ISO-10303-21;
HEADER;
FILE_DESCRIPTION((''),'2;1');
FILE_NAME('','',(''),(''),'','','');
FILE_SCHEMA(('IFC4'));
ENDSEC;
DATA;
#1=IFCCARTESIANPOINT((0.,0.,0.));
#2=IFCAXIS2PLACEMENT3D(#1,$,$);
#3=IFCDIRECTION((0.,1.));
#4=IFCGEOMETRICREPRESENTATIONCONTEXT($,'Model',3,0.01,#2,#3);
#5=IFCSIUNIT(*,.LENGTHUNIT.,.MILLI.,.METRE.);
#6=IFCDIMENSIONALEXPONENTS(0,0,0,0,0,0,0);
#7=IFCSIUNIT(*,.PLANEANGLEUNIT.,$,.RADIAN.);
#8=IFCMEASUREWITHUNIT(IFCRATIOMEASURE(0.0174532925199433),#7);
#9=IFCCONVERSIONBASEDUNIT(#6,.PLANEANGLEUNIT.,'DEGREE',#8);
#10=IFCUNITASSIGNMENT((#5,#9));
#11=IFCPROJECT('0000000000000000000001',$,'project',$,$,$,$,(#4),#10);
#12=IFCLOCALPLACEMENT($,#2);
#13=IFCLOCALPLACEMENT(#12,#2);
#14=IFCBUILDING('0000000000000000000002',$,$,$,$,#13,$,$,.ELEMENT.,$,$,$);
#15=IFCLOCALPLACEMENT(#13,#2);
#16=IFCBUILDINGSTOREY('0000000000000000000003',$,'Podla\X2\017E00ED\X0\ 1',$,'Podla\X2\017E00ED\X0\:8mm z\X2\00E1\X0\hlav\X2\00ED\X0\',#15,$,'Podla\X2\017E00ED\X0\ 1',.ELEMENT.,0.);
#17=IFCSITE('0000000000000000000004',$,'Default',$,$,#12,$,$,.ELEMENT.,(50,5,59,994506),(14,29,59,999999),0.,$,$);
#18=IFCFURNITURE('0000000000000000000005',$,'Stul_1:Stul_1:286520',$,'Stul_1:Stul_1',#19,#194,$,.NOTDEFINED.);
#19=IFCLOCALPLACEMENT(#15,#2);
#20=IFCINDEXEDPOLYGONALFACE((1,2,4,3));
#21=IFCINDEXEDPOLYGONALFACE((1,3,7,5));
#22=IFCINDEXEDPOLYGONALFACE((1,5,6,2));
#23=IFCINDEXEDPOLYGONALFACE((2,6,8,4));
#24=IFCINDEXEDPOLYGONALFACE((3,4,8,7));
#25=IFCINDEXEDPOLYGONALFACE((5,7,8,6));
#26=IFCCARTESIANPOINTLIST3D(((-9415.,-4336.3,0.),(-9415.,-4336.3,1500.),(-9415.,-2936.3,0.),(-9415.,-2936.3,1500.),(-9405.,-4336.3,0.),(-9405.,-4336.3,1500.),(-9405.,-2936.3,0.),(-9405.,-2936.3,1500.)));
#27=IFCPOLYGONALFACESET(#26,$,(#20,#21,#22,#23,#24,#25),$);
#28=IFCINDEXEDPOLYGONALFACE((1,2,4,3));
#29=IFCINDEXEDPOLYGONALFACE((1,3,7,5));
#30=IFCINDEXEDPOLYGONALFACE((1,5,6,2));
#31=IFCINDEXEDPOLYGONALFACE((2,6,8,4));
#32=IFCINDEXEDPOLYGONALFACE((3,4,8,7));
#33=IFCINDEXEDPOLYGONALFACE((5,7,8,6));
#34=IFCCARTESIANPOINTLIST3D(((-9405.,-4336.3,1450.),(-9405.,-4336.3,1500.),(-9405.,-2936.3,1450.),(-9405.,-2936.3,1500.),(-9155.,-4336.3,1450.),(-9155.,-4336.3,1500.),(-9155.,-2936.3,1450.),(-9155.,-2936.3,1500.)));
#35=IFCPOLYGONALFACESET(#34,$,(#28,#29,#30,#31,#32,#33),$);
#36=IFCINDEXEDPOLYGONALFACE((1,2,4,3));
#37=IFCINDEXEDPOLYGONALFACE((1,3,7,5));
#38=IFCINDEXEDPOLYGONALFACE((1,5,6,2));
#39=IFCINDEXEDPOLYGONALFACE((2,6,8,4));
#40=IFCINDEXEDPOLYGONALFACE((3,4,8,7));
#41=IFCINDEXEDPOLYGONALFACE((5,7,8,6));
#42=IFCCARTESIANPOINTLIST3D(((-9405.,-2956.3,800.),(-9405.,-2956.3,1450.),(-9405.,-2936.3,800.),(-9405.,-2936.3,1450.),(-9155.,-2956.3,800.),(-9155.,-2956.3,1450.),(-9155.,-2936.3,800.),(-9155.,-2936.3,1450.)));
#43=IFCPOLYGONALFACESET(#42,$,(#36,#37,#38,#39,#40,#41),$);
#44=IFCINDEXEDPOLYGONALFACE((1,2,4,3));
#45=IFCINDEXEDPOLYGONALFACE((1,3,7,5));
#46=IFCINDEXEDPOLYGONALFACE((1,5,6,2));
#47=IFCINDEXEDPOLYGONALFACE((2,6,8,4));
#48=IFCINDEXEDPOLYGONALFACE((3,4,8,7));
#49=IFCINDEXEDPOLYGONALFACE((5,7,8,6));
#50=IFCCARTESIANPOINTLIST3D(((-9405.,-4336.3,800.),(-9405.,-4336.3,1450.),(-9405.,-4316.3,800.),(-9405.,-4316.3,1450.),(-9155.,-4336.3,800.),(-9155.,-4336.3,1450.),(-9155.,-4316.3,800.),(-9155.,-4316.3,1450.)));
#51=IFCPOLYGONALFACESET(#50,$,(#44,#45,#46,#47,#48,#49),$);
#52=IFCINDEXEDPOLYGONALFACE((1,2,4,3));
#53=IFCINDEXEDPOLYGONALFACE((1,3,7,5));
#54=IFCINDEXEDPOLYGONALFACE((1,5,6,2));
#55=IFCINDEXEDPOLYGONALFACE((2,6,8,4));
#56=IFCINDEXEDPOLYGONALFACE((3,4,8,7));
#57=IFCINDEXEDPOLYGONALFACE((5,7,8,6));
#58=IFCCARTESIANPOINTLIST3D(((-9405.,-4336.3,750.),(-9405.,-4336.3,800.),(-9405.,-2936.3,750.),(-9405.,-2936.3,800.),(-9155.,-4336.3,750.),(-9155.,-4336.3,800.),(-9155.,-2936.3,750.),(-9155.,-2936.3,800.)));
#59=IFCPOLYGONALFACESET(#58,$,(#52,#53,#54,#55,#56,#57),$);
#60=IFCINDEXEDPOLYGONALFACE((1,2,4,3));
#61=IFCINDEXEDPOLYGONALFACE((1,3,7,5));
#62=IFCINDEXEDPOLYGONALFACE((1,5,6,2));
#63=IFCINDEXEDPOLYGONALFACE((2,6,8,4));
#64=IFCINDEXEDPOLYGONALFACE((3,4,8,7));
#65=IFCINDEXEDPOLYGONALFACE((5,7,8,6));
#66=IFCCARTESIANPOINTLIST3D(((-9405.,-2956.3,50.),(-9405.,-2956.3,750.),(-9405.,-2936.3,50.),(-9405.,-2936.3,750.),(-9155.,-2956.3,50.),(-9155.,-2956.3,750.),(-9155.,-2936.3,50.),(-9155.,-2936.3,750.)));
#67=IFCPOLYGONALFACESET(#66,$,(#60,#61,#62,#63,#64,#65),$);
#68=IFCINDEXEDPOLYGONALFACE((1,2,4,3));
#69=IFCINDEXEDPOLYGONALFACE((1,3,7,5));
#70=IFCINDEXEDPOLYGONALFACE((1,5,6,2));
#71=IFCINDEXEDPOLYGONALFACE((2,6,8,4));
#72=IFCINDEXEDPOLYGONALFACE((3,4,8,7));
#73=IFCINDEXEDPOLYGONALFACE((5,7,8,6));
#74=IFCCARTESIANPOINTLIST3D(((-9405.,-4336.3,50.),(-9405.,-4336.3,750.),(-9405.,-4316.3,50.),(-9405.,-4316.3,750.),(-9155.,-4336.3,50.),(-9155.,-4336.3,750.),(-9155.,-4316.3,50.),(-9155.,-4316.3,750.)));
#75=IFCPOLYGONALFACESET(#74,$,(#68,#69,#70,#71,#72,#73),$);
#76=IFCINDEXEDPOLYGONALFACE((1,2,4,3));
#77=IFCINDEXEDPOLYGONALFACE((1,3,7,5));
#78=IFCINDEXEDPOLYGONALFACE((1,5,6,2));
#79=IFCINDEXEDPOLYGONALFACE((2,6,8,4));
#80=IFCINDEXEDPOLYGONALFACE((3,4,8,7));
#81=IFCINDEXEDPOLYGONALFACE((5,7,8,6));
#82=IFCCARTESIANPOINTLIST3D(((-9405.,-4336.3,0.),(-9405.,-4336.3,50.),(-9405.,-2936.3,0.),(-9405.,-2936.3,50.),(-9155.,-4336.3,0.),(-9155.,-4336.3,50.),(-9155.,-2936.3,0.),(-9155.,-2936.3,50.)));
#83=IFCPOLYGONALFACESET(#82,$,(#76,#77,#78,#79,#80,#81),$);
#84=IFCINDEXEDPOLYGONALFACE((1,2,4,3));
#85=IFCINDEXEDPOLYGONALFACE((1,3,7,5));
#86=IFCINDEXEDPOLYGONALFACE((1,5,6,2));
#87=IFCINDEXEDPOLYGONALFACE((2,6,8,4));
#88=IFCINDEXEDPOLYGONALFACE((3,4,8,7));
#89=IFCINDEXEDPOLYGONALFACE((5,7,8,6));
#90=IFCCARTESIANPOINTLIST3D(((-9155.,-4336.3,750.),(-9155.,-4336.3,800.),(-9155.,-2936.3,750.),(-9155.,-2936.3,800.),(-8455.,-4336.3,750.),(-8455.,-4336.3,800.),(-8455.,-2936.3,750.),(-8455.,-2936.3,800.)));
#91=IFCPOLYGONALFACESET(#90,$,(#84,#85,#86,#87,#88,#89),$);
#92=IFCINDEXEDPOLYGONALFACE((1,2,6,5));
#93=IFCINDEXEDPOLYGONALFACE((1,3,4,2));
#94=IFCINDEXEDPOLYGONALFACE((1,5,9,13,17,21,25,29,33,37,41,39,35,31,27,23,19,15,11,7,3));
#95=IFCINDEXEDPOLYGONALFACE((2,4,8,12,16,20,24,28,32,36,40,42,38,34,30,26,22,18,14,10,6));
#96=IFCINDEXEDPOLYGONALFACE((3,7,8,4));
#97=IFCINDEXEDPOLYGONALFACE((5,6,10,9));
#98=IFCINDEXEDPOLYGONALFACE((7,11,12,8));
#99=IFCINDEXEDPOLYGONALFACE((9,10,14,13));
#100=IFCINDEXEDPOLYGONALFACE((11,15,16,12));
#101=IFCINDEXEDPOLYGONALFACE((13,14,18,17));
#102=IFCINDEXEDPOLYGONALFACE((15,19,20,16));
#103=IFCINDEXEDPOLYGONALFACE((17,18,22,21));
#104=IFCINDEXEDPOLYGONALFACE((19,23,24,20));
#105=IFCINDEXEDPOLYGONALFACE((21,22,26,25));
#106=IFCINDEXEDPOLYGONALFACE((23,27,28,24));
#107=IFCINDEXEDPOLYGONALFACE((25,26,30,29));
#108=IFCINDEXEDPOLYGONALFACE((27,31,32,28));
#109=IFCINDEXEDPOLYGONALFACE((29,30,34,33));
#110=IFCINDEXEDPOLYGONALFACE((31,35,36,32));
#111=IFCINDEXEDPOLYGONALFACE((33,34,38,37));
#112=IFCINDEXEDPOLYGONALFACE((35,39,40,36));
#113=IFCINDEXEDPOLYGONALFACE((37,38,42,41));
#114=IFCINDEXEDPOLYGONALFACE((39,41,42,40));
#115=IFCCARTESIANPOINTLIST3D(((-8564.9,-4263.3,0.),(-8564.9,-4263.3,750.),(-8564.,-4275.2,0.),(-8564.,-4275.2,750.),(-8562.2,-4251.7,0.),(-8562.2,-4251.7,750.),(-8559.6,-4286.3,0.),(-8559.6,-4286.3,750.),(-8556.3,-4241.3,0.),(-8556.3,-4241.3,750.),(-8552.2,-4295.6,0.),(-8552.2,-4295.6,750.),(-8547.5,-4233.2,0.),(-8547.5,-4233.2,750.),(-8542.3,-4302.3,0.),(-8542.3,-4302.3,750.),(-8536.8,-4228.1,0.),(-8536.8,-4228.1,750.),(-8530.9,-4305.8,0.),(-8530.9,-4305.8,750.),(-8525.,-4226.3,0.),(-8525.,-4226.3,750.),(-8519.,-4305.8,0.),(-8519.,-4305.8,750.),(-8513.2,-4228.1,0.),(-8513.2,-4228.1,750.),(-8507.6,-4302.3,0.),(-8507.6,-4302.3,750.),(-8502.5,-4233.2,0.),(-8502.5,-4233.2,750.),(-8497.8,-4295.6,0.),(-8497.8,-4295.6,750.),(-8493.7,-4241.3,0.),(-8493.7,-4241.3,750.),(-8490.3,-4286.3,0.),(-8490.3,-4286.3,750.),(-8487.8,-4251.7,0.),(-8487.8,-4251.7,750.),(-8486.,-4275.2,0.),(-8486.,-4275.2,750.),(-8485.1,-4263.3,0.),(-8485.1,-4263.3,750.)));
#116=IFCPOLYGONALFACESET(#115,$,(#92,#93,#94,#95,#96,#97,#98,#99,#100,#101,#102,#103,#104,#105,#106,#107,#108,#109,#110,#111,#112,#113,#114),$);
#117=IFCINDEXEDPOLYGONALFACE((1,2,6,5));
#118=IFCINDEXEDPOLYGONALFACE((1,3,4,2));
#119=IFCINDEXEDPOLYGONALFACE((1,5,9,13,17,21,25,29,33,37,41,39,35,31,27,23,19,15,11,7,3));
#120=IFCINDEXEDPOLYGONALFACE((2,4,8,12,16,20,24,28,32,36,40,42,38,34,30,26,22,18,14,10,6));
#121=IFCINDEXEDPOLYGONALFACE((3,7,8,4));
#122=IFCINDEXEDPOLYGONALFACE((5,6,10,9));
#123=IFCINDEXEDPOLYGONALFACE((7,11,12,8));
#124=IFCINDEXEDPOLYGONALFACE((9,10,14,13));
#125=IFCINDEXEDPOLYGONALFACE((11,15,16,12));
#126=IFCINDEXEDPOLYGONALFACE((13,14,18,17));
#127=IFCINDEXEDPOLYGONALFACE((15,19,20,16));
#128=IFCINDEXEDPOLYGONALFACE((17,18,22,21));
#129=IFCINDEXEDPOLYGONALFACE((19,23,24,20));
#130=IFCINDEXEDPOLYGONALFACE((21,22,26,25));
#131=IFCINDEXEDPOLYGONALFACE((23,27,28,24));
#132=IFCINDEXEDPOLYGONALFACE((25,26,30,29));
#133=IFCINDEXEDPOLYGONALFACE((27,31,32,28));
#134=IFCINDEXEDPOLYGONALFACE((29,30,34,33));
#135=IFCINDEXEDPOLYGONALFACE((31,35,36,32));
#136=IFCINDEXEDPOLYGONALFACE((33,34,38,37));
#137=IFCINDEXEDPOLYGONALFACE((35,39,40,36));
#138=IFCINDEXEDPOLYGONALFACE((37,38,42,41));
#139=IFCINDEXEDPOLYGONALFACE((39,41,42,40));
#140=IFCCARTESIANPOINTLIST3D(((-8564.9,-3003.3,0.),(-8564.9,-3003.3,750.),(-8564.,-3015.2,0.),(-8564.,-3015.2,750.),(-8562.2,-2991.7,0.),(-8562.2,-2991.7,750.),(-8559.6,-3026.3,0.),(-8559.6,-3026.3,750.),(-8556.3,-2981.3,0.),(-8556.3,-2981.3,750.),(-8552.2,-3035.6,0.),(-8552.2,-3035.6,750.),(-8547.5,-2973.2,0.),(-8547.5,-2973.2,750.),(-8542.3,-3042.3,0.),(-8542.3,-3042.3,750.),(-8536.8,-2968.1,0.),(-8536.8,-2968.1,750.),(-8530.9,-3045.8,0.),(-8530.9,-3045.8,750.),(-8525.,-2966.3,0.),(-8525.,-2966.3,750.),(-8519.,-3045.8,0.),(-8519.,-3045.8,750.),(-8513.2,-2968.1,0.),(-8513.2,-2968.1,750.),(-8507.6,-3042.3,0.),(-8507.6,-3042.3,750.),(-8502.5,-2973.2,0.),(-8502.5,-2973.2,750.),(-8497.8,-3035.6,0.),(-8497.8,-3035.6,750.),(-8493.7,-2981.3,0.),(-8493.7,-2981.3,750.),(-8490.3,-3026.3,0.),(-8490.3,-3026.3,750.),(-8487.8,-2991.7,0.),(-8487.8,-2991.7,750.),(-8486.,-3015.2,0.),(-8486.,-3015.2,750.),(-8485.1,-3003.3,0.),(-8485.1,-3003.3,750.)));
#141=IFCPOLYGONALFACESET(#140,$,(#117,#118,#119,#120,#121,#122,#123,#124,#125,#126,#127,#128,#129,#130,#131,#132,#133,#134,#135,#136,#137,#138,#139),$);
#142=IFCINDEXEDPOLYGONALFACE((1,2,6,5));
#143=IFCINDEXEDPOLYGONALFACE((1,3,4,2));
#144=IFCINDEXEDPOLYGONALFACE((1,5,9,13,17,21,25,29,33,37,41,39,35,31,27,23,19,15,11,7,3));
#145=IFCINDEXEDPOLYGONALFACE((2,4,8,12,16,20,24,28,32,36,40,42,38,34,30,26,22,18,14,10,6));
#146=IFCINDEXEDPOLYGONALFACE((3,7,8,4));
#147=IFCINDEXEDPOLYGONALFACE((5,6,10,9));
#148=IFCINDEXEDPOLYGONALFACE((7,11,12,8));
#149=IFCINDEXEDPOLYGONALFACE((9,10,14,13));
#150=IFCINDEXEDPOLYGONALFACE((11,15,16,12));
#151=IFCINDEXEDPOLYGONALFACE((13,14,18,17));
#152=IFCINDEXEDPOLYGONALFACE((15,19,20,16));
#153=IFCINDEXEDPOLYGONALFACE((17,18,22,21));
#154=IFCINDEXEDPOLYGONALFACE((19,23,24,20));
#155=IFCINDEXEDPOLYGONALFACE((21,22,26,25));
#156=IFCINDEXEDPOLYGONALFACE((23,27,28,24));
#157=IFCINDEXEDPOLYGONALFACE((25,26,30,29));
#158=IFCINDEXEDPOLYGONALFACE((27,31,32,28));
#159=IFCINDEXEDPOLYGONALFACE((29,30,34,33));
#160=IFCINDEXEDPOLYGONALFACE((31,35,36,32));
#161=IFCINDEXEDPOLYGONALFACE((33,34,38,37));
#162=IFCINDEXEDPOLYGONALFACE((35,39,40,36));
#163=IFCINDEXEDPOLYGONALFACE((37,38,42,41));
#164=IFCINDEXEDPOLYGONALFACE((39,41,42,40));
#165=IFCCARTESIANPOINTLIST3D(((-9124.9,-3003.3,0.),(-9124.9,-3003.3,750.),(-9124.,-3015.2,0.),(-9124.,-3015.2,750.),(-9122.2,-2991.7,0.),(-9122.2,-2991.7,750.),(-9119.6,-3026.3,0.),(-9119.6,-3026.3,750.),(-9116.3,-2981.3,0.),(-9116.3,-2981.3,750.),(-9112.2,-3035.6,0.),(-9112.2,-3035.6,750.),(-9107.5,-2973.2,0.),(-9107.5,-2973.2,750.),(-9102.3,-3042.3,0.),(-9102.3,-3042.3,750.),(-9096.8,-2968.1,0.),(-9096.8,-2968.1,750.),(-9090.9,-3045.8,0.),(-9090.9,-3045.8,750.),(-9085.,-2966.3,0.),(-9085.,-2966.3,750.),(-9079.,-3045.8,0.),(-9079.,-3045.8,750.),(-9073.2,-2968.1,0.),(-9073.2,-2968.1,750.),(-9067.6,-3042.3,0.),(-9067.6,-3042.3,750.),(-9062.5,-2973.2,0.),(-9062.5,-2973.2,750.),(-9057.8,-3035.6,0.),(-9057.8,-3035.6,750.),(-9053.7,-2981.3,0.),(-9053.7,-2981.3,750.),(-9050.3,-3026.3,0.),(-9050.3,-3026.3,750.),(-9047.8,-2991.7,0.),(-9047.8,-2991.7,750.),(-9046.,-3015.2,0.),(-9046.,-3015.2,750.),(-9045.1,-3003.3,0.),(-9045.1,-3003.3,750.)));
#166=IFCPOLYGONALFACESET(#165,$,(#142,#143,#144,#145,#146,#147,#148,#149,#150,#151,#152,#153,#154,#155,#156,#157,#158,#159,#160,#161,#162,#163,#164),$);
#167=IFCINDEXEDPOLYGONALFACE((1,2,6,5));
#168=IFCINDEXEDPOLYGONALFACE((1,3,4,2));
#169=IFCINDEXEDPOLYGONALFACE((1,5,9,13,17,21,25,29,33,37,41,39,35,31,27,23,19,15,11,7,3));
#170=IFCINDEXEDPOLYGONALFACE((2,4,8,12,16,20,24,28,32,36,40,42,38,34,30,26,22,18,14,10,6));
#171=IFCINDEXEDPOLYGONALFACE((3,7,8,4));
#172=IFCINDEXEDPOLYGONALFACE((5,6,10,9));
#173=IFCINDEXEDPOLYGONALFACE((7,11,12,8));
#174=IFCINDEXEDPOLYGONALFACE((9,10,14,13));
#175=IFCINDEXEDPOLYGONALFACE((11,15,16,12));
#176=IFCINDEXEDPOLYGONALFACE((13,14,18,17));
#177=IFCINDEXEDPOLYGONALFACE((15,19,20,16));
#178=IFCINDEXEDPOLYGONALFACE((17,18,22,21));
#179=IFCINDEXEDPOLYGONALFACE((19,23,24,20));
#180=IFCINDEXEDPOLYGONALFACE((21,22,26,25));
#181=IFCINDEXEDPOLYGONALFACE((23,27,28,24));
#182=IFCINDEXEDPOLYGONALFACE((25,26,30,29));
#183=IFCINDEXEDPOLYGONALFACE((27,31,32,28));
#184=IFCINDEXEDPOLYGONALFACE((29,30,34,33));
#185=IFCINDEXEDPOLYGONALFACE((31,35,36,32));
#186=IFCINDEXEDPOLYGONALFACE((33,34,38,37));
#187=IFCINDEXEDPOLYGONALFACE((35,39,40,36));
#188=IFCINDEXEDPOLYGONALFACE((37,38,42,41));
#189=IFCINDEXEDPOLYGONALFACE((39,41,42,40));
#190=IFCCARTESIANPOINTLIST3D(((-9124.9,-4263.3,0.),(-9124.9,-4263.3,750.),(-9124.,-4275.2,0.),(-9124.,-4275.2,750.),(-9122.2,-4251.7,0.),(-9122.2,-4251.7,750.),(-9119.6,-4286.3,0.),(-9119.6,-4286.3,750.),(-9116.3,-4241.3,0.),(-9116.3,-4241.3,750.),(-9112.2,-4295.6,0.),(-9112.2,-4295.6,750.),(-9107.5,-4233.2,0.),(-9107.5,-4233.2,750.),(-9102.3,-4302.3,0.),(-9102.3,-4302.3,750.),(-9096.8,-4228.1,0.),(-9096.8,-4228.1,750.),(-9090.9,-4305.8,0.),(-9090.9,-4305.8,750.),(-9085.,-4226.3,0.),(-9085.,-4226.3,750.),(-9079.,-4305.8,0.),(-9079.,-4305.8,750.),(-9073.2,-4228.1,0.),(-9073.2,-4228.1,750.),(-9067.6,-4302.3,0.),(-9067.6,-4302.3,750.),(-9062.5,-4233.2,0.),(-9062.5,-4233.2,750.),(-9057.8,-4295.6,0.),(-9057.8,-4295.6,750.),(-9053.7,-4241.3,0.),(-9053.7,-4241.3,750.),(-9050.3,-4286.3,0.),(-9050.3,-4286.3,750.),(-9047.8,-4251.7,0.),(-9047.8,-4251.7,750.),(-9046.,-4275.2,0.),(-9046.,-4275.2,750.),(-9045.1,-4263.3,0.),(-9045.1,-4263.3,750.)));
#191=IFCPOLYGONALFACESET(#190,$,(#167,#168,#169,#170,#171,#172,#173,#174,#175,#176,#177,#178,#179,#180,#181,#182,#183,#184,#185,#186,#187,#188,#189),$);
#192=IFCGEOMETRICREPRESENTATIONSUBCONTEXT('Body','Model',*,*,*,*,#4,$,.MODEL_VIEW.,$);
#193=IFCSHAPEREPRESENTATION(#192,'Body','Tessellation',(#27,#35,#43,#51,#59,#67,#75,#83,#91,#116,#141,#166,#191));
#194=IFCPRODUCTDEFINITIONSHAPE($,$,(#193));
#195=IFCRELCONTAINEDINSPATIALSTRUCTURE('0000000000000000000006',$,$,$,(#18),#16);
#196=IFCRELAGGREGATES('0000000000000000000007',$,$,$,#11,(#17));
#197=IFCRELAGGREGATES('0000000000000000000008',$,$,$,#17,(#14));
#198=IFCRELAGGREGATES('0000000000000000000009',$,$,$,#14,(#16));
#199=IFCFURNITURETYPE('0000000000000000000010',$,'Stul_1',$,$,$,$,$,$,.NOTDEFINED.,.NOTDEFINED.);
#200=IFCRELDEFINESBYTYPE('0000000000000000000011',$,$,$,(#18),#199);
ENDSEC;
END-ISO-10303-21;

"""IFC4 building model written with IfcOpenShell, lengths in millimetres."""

from ifc_helpers import new_model, entity, si_unit, converted_unit, direction, frame, frame_2d, origin, origin_2d_with_axis, place, context, subcontext, project, spatial, rectangle, circle, extrude, source, transform, mapped, type_object, type_shapes, element, save


model = new_model("IFC4")

# Units and contexts
model_context = context("Model", 3, precision=0.01, world=origin(), true_north=direction((0.0, 1.0)))
body_context = subcontext(model_context, "Body", "Model", "MODEL_VIEW")
ifc_project = project(units=[si_unit("LENGTHUNIT", "METRE", prefix="MILLI"), converted_unit("PLANEANGLEUNIT", "DEGREE", entity("IfcRatioMeasure", 0.0174532925199433), si_unit("PLANEANGLEUNIT", "RADIAN"), dimensions=[0, 0, 0, 0, 0, 0, 0])], contexts=[model_context])

# Site, building, storey
site_placement = place(None, origin())
site = spatial("IfcSite", under=ifc_project, at=site_placement, Name="Default", CompositionType="ELEMENT", RefLatitude=(50, 5, 59, 994506), RefLongitude=(14, 29, 59, 999999), RefElevation=0.0)
building_placement = place(site_placement, origin())
building = spatial("IfcBuilding", under=site, at=building_placement, CompositionType="ELEMENT")
storey_placement = place(building_placement, origin())
storey = spatial("IfcBuildingStorey", under=building, at=storey_placement, Name="Podlaží 1", ObjectType="Podlaží:8mm záhlaví", LongName="Podlaží 1", CompositionType="ELEMENT", Elevation=0.0)

# Furniture
furniture_type = type_object("IfcFurnitureType", Name="Stul_1", AssemblyPlace="NOTDEFINED", PredefinedType="NOTDEFINED")
shared_shape_1 = source(origin(), body_context, "Body", "SweptSolid", [
    extrude(rectangle(XDim=1400.0, YDim=10.0, at=origin_2d_with_axis()), frame((0.0, 605.0, 0.0), z_axis=(0.0, 0.0, 1.0), x_axis=(-1.0, 0.0, 0.0)), (0.0, 0.0, 1.0), 1500.0),
    extrude(rectangle(XDim=1400.0, YDim=250.0, at=frame_2d((0.0, 0.0), x_axis=(1.0, 0.0))), frame((0.0, 475.0, 1450.0), z_axis=(0.0, 0.0, 1.0), x_axis=(-1.0, 0.0, 0.0)), (0.0, 0.0, 1.0), 50.0),
    extrude(rectangle(XDim=20.0, YDim=250.0, at=origin_2d_with_axis()), frame((690.0, 475.0, 800.0), z_axis=(0.0, 0.0, 1.0), x_axis=(-1.0, 0.0, 0.0)), (0.0, 0.0, 1.0), 650.0),
    extrude(rectangle(XDim=20.0, YDim=250.0, at=frame_2d((0.0, 0.0), x_axis=(1.0, 0.0))), frame((-690.0, 475.0, 800.0), z_axis=(0.0, 0.0, 1.0), x_axis=(-1.0, 0.0, 0.0)), (0.0, 0.0, 1.0), 650.0),
    extrude(rectangle(XDim=1400.0, YDim=250.0, at=origin_2d_with_axis()), frame((0.0, 475.0, 750.0), z_axis=(0.0, 0.0, 1.0), x_axis=(-1.0, 0.0, 0.0)), (0.0, 0.0, 1.0), 50.0),
    extrude(rectangle(XDim=20.0, YDim=250.0, at=origin_2d_with_axis()), frame((690.0, 475.0, 50.0), z_axis=(0.0, 0.0, 1.0), x_axis=(-1.0, 0.0, 0.0)), (0.0, 0.0, 1.0), 700.0),
    extrude(rectangle(XDim=20.0, YDim=250.0, at=frame_2d((0.0, 0.0), x_axis=(1.0, 0.0))), frame((-690.0, 475.0, 50.0), z_axis=(0.0, 0.0, 1.0), x_axis=(-1.0, 0.0, 0.0)), (0.0, 0.0, 1.0), 700.0),
    extrude(rectangle(XDim=1400.0, YDim=250.0, at=origin_2d_with_axis()), frame((0.0, 475.0, 0.0), z_axis=(0.0, 0.0, 1.0), x_axis=(-1.0, 0.0, 0.0)), (0.0, 0.0, 1.0), 50.0),
    extrude(rectangle(XDim=1400.0, YDim=700.0, at=origin_2d_with_axis()), frame((0.0, 0.0, 750.0), z_axis=(0.0, 0.0, 1.0), x_axis=(-1.0, 0.0, 0.0)), (0.0, 0.0, 1.0), 50.0),
    extrude(circle(Radius=40.0, at=frame_2d((0.0, 0.0), x_axis=(1.0, 0.0))), frame((-630.0, -280.0, 0.0)), (0.0, 0.0, 1.0), 750.0),
    extrude(circle(Radius=40.0, at=frame_2d((0.0, 0.0), x_axis=(1.0, 0.0))), frame((630.0, -280.0, 0.0)), (0.0, 0.0, 1.0), 750.0),
    extrude(circle(Radius=40.0, at=frame_2d((0.0, 0.0), x_axis=(1.0, 0.0))), frame((630.0, 280.0, 0.0)), (0.0, 0.0, 1.0), 750.0),
    extrude(circle(Radius=40.0, at=frame_2d((0.0, 0.0), x_axis=(1.0, 0.0))), frame((-630.0, 280.0, 0.0)), (0.0, 0.0, 1.0), 750.0),
])
type_shapes(furniture_type, [shared_shape_1])
for number, where, z_axis, x_axis, name in (
    (1, (-8805.0, -3636.3, 0.0), (0.0, 0.0, 1.0), (0.0, 1.0, 0.0), "Stul_1:Stul_1:286520"),
):
    element("IfcFurniture", number, at=place(storey_placement, frame(where, z_axis=z_axis, x_axis=x_axis)), inside=storey, type_object=furniture_type, Name=name, ObjectType="Stul_1:Stul_1", PredefinedType="NOTDEFINED", context=body_context, shape_type="MappedRepresentation", body=[
        mapped(shared_shape_1, transform((0.0, 0.0, 0.0), scale=1.0)),
    ])

save(model, "model.ifc")
